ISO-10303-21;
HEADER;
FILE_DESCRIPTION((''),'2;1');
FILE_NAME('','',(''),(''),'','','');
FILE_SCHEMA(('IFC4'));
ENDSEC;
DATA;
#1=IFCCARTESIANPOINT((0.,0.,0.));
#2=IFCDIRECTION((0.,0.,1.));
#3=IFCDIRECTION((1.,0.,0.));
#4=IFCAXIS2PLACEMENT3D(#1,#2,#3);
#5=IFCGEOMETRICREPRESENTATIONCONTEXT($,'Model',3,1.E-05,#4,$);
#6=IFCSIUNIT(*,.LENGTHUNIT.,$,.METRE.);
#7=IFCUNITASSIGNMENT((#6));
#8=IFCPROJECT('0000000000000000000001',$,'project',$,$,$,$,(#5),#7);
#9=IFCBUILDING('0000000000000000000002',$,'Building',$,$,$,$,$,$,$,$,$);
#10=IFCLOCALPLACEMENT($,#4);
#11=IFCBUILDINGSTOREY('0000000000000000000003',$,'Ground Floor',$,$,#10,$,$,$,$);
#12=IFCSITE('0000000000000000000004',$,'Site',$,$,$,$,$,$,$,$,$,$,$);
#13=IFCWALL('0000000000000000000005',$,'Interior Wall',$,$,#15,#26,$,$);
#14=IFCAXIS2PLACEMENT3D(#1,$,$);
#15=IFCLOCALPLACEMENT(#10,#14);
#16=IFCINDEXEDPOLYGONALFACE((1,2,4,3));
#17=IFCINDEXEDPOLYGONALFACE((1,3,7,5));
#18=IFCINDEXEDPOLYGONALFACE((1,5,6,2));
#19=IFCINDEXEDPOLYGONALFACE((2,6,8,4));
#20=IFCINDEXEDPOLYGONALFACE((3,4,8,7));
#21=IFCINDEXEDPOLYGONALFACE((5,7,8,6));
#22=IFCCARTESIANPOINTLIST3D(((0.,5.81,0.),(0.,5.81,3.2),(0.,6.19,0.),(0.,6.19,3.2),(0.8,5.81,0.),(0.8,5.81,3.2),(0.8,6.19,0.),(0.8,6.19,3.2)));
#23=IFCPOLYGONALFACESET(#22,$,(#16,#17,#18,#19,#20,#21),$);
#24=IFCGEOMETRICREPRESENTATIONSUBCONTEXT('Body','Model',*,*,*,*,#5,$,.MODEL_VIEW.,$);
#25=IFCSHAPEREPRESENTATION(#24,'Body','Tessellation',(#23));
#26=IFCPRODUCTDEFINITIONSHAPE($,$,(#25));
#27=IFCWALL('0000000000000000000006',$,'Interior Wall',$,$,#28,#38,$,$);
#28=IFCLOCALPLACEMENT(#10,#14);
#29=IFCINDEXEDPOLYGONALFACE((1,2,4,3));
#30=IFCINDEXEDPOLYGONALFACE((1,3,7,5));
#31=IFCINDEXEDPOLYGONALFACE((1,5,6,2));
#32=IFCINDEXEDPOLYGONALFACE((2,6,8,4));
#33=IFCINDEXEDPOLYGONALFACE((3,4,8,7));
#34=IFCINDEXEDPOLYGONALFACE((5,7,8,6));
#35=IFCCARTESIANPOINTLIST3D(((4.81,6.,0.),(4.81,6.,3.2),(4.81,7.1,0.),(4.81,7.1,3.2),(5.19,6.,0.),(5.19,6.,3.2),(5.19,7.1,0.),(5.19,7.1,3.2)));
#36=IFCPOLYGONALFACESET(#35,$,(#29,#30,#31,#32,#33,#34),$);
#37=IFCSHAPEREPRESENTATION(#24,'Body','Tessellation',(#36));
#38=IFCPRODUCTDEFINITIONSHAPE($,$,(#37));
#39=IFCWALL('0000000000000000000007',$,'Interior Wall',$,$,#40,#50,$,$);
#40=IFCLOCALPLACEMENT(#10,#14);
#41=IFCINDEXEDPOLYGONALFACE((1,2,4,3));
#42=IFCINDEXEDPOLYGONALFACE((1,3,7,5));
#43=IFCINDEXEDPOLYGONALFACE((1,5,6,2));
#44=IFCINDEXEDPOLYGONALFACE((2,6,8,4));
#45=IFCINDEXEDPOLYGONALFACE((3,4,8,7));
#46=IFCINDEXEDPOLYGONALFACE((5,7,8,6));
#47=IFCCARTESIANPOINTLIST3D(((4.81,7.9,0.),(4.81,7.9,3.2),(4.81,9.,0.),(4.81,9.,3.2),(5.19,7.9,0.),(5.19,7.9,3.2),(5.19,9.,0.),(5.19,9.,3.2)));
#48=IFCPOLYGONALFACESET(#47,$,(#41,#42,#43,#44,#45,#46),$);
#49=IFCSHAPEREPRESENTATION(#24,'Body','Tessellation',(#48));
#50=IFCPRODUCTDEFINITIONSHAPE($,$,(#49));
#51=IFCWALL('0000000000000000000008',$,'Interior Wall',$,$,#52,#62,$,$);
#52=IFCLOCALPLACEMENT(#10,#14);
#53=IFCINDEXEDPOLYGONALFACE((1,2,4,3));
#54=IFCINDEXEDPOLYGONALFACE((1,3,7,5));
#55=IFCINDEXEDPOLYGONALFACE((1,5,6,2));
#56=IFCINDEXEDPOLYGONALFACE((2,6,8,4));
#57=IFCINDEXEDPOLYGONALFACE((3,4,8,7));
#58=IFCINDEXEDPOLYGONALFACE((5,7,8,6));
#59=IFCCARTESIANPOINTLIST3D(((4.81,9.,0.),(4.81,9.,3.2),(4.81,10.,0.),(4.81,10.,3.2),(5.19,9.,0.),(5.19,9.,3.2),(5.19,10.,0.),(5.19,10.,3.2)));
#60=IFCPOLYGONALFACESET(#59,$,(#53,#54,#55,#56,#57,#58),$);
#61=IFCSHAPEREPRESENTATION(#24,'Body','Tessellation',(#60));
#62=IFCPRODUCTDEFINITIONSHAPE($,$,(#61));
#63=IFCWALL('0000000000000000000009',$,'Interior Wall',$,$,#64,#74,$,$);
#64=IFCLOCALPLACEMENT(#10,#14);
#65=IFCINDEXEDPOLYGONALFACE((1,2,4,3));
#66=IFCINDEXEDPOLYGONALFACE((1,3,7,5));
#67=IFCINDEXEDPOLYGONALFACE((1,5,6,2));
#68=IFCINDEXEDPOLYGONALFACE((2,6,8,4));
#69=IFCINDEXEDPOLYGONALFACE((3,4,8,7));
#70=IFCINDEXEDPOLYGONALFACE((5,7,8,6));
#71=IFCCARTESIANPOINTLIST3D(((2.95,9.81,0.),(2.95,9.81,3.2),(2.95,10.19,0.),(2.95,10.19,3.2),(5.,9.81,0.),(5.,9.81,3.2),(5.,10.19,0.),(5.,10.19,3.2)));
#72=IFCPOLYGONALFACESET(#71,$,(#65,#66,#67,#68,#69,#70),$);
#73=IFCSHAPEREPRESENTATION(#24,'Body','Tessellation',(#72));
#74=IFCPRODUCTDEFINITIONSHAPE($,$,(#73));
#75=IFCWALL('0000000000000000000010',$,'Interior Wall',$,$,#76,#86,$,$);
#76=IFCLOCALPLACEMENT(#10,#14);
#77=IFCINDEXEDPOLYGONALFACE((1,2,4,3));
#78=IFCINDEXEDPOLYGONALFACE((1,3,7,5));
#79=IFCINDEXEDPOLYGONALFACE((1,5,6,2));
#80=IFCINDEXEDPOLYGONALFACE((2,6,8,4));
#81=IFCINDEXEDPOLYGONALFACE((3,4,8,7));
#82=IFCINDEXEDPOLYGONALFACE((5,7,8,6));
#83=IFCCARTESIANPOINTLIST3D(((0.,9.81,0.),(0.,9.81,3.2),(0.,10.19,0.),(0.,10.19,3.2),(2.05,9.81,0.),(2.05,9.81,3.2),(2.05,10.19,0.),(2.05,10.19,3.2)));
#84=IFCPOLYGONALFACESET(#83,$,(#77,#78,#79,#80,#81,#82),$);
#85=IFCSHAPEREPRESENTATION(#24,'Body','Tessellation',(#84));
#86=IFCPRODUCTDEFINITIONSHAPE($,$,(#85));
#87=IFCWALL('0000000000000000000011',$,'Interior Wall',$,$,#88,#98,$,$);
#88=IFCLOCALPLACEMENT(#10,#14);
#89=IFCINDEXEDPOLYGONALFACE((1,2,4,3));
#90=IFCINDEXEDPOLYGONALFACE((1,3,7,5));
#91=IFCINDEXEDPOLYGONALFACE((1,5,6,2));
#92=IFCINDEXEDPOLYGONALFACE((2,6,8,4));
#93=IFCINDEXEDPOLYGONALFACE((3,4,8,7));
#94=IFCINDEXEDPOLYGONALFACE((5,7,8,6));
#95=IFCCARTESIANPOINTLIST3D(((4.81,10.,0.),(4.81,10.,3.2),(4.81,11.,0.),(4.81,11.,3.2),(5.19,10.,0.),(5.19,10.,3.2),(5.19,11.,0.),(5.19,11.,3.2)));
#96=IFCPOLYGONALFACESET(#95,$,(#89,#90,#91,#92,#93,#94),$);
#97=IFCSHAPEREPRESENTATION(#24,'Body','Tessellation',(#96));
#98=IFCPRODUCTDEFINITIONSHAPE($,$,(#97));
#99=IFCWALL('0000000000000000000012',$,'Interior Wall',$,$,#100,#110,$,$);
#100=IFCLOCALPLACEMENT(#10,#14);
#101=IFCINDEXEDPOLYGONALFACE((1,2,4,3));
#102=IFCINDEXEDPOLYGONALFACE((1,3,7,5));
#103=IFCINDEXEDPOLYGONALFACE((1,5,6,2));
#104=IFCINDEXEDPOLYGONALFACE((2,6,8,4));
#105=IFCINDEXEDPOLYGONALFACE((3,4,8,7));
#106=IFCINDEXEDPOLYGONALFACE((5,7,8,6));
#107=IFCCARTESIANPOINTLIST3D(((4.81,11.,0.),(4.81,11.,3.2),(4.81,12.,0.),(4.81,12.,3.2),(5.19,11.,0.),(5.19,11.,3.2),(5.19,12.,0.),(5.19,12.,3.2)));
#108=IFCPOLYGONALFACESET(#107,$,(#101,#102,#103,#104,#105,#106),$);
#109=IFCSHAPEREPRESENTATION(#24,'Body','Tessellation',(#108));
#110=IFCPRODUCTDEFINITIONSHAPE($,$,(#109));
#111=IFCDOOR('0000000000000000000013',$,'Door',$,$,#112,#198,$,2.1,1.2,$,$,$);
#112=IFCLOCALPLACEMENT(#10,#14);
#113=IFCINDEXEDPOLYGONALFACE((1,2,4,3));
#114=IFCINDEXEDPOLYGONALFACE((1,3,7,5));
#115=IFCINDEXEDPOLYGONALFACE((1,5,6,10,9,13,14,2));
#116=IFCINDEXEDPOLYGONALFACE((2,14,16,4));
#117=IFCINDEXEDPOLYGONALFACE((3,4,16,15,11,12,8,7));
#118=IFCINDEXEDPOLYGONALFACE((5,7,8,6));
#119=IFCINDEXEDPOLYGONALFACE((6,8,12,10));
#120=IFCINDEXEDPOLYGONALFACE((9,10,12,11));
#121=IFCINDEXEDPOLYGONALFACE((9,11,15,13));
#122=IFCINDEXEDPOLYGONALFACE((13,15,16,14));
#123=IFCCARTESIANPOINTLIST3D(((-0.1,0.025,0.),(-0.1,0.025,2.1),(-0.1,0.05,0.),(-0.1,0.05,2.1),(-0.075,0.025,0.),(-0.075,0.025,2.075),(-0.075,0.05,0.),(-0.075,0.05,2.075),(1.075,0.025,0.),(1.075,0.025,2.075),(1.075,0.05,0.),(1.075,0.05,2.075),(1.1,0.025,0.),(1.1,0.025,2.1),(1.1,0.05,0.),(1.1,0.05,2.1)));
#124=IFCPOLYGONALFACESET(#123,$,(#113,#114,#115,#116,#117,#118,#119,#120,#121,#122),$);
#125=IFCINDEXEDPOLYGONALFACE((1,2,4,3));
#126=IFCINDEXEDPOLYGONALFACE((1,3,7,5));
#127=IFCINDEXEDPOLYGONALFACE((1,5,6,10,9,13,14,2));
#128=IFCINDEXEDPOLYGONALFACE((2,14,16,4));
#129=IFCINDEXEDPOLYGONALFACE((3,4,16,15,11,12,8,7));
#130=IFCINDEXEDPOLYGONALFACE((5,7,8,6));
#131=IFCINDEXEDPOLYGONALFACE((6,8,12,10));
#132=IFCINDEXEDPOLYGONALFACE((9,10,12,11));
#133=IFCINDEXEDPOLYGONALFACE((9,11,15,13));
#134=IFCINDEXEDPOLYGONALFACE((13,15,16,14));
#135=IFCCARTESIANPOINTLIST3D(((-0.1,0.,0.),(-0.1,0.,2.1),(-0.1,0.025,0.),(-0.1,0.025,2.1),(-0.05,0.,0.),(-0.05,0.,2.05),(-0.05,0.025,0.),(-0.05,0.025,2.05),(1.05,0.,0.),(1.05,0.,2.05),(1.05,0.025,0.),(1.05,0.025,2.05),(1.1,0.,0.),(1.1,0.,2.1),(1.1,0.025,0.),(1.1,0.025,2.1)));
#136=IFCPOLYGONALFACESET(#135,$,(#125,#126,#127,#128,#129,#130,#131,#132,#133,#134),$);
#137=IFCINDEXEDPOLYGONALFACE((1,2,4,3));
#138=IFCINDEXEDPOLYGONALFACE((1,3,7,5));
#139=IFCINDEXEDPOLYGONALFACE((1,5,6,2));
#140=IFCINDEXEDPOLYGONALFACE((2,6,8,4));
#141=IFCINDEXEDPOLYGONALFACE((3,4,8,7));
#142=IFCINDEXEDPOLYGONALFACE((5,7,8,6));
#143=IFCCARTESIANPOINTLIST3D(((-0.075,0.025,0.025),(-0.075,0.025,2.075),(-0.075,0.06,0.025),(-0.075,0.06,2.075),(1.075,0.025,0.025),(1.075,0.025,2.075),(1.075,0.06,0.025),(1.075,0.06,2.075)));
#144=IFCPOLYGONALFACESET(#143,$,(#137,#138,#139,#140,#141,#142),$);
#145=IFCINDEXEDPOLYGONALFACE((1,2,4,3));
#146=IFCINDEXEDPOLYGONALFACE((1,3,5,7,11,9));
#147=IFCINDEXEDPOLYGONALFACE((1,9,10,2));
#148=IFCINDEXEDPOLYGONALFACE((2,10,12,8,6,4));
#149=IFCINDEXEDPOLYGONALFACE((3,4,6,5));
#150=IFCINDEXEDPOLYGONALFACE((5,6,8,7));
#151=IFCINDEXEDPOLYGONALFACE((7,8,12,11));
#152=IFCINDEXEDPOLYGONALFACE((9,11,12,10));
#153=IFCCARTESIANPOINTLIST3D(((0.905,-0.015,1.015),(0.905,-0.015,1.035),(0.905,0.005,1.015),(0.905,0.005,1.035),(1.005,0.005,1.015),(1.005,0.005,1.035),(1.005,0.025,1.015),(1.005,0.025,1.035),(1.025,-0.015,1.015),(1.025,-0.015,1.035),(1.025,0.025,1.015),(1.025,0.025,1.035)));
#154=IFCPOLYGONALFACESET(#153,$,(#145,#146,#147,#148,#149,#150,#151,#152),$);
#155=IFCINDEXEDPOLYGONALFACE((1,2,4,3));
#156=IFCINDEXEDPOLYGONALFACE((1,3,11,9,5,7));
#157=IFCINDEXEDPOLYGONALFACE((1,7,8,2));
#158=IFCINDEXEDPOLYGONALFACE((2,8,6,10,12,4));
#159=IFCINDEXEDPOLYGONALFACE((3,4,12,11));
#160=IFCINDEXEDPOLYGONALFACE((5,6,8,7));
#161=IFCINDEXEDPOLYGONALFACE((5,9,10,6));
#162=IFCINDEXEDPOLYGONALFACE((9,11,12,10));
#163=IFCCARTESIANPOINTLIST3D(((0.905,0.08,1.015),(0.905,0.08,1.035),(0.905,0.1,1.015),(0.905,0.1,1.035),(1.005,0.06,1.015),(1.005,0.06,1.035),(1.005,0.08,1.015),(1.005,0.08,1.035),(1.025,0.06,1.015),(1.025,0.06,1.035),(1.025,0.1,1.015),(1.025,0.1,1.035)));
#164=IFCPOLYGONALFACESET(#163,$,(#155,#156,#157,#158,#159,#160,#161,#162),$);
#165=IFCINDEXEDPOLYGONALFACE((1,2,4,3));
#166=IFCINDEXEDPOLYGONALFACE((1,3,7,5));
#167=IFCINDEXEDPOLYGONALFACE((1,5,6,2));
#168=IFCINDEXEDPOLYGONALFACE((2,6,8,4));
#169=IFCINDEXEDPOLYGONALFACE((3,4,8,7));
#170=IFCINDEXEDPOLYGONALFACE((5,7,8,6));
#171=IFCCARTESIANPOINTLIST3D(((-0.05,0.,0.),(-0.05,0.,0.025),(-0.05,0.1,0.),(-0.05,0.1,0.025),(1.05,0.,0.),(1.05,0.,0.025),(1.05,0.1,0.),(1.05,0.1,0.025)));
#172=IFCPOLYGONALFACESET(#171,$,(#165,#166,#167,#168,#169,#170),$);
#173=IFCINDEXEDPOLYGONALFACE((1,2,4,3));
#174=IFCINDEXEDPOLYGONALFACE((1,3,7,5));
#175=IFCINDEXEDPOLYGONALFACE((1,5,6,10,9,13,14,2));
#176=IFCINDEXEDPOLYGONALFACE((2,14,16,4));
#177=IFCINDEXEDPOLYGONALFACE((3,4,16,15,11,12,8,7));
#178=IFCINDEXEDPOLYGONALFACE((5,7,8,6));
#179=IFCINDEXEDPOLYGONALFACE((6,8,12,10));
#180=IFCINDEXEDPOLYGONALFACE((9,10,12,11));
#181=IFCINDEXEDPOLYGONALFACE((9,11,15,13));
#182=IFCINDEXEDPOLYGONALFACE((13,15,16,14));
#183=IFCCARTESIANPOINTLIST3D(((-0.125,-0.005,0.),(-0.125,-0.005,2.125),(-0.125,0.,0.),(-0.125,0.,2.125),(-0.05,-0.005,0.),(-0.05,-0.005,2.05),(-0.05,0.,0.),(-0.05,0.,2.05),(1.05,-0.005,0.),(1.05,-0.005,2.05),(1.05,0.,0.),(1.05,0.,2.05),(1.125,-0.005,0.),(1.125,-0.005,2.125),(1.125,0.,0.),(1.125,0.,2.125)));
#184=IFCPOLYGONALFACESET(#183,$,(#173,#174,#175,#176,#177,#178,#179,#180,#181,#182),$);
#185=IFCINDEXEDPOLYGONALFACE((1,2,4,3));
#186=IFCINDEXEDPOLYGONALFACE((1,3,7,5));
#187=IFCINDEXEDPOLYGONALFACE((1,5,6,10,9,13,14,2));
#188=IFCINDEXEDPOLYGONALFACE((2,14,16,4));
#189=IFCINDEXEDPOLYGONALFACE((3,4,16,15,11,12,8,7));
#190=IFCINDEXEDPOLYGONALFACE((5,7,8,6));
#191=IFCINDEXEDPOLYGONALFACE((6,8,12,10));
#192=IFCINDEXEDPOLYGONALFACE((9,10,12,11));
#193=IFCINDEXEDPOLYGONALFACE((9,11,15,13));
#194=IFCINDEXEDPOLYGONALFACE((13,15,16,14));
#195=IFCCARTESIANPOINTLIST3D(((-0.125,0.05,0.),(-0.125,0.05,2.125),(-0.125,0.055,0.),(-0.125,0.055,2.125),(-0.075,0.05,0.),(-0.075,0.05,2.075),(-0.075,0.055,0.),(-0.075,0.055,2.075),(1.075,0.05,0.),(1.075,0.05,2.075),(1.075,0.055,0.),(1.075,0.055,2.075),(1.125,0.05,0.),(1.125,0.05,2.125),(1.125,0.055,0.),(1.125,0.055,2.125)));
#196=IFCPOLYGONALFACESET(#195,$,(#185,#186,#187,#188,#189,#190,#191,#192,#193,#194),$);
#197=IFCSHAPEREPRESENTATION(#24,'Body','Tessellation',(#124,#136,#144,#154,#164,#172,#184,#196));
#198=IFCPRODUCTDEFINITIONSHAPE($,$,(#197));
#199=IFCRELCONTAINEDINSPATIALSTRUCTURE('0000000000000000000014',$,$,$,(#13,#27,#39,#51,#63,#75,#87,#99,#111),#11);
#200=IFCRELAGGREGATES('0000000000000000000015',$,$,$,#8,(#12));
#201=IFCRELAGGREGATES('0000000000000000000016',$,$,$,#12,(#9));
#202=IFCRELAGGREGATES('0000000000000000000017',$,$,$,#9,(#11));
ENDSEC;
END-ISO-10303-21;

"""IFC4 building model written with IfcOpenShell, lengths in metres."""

from ifc_helpers import new_model, si_unit, frame, origin_with_axes, place, context, subcontext, project, spatial, line, indexed_curve, outline, extrude, element, save


model = new_model("IFC4")

# Units and contexts
model_context = context("Model", 3, precision=1e-05, world=origin_with_axes())
body_context = subcontext(model_context, "Body", "Model", "MODEL_VIEW")
ifc_project = project(units=[si_unit("LENGTHUNIT", "METRE")], contexts=[model_context])

# Site, building, storey
site = spatial("IfcSite", under=ifc_project, Name="Site")
building = spatial("IfcBuilding", under=site, Name="Building")
storey_placement = place(None, origin_with_axes())
storey = spatial("IfcBuildingStorey", under=building, at=storey_placement, Name="Ground Floor")

# Walls
for number, where, z_axis, x_axis, name in (
    (1, (0.8, 6.0, 0.0), (0.0, 0.0, 1.0), (-1.0, 0.0, 0.0), "Interior Wall"),
):
    element("IfcWall", number, at=place(storey_placement, frame(where, z_axis=z_axis, x_axis=x_axis)), inside=storey, Name=name, context=body_context, shape_type="SweptSolid", body=[
        extrude(outline(indexed_curve([(0.0, 0.0), (0.0, 0.38), (0.8, 0.38), (0.8, 0.0), (0.0, 0.0)], self_intersect=False)), frame((0.0, -0.19, 0.0), z_axis=(0.0, 0.0, 1.0), x_axis=(1.0, 0.0, 0.0)), (0.0, 0.0, 1.0), 3.2),
    ])
for number, where, z_axis, x_axis, name in (
    (2, (5.0, 6.0, 0.0), (0.0, 0.0, 1.0), (0.0, 1.0, 0.0), "Interior Wall"),
    (3, (5.0, 7.9, 0.0), (0.0, 0.0, 1.0), (0.0, 1.0, 0.0), "Interior Wall"),
):
    element("IfcWall", number, at=place(storey_placement, frame(where, z_axis=z_axis, x_axis=x_axis)), inside=storey, Name=name, context=body_context, shape_type="SweptSolid", body=[
        extrude(outline(indexed_curve([(0.0, 0.0), (0.0, 0.38), (1.1, 0.38), (1.1, 0.0), (0.0, 0.0)], self_intersect=False)), frame((0.0, -0.19, 0.0), z_axis=(0.0, 0.0, 1.0), x_axis=(1.0, 0.0, 0.0)), (0.0, 0.0, 1.0), 3.2),
    ])
wall_1_placement = place(storey_placement, frame((5.0, 9.0, 0.0), z_axis=(0.0, 0.0, 1.0), x_axis=(0.0, 1.0, 0.0)))
element("IfcWall", 4, at=wall_1_placement, inside=storey, Name="Interior Wall", context=body_context, shape_type="SweptSolid", body=[
    extrude(outline(indexed_curve([(0.0, 0.0), (0.0, 0.38), (1.0, 0.38), (1.0, 0.0), (0.0, 0.0)], self_intersect=False)), frame((0.0, -0.19, 0.0), z_axis=(0.0, 0.0, 1.0), x_axis=(1.0, 0.0, 0.0)), (0.0, 0.0, 1.0), 3.2),
])
for number, where, z_axis, x_axis, name in (
    (5, (5.0, 10.0, 0.0), (0.0, 0.0, 1.0), (-1.0, 0.0, 0.0), "Interior Wall"),
    (6, (2.05, 10.0, 0.0), (0.0, 0.0, 1.0), (-1.0, 0.0, 0.0), "Interior Wall"),
):
    element("IfcWall", number, at=place(storey_placement, frame(where, z_axis=z_axis, x_axis=x_axis)), inside=storey, Name=name, context=body_context, shape_type="SweptSolid", body=[
        extrude(outline(indexed_curve([(0.0, 0.0), (0.0, 0.38), (2.05, 0.38), (2.05, 0.0), (0.0, 0.0)], self_intersect=False)), frame((0.0, -0.19, 0.0), z_axis=(0.0, 0.0, 1.0), x_axis=(1.0, 0.0, 0.0)), (0.0, 0.0, 1.0), 3.2),
    ])
for number, where, z_axis, x_axis, name in (
    (7, (5.0, 11.0, 0.0), (0.0, 0.0, 1.0), (0.0, -1.0, 0.0), "Interior Wall"),
    (8, (5.0, 11.0, 0.0), (0.0, 0.0, 1.0), (0.0, 1.0, 0.0), "Interior Wall"),
):
    element("IfcWall", number, at=place(storey_placement, frame(where, z_axis=z_axis, x_axis=x_axis)), inside=storey, Name=name, context=body_context, shape_type="SweptSolid", body=[
        extrude(outline(indexed_curve([(0.0, 0.0), (0.0, 0.38), (1.0, 0.38), (1.0, 0.0), (0.0, 0.0)], self_intersect=False)), frame((0.0, -0.19, 0.0), z_axis=(0.0, 0.0, 1.0), x_axis=(1.0, 0.0, 0.0)), (0.0, 0.0, 1.0), 3.2),
    ])

# Door
door_1_placement = place(storey_placement, frame((-0.1, 0.0, 0.0), z_axis=(0.0, 0.0, 1.0), x_axis=(1.0, 0.0, 0.0)))
element("IfcDoor", 9, at=door_1_placement, inside=storey, Name="Door", OverallHeight=2.1, OverallWidth=1.2, context=body_context, shape_type="SweptSolid", body=[
    extrude(outline(indexed_curve([(0.0, 0.0), (0.0, 2.1), (1.2, 2.1), (1.2, 0.0), (1.175, 0.0), (1.175, 2.075), (0.025, 2.075), (0.025, 0.0)], segments=[line(1, 2, 3, 4, 5, 6, 7, 8, 1)])), frame((0.0, 0.025, 0.0), z_axis=(0.0, -1.0, 0.0), x_axis=(1.0, 0.0, 0.0)), (0.0, 0.0, -1.0), 0.025),
    extrude(outline(indexed_curve([(0.0, 0.0), (0.0, 2.1), (1.2, 2.1), (1.2, 0.0), (1.15, 0.0), (1.15, 2.05), (0.05, 2.05), (0.05, 0.0)], segments=[line(1, 2, 3, 4, 5, 6, 7, 8, 1)])), frame((0.0, 0.0, 0.0), z_axis=(0.0, -1.0, 0.0), x_axis=(1.0, 0.0, 0.0)), (0.0, 0.0, -1.0), 0.025),
    extrude(outline(indexed_curve([(0.0, 0.0), (1.15, 0.0), (1.15, 0.035), (0.0, 0.035)], segments=[line(1, 2, 3, 4, 1)])), frame((0.025, 0.025, 0.025), z_axis=(0.0, 0.0, 1.0), x_axis=(1.0, 0.0, 0.0)), (0.0, 0.0, 1.0), 2.05),
    extrude(outline(indexed_curve([(0.0, 0.0), (0.0, -0.04), (-0.12, -0.04), (-0.12, -0.02), (-0.02, -0.02), (-0.02, 0.0)], segments=[line(1, 2, 3, 4, 5, 6, 1)])), frame((1.125, 0.025, 1.015), z_axis=(0.0, 0.0, 1.0), x_axis=(1.0, 0.0, 0.0)), (0.0, 0.0, 1.0), 0.02),
    extrude(outline(indexed_curve([(0.0, 0.0), (0.0, 0.04), (-0.12, 0.04), (-0.12, 0.02), (-0.02, 0.02), (-0.02, 0.0)], segments=[line(1, 2, 3, 4, 5, 6, 1)])), frame((1.125, 0.06, 1.015), z_axis=(0.0, 0.0, 1.0), x_axis=(1.0, 0.0, 0.0)), (0.0, 0.0, 1.0), 0.02),
    extrude(outline(indexed_curve([(0.0, 0.0), (1.1, 0.0), (1.1, 0.1), (0.0, 0.1)], segments=[line(1, 2, 3, 4, 1)])), frame((0.05, 0.0, 0.0), z_axis=(0.0, 0.0, 1.0), x_axis=(1.0, 0.0, 0.0)), (0.0, 0.0, 1.0), 0.025),
    extrude(outline(indexed_curve([(0.0, 0.0), (0.0, 2.125), (1.25, 2.125), (1.25, 0.0), (1.175, 0.0), (1.175, 2.05), (0.075, 2.05), (0.075, 0.0)], segments=[line(1, 2, 3, 4, 5, 6, 7, 8, 1)])), frame((-0.025, -0.005, 0.0), z_axis=(0.0, -1.0, 0.0), x_axis=(1.0, 0.0, 0.0)), (0.0, 0.0, -1.0), 0.005),
    extrude(outline(indexed_curve([(0.0, 0.0), (0.0, 2.125), (1.25, 2.125), (1.25, 0.0), (1.2, 0.0), (1.2, 2.075), (0.05, 2.075), (0.05, 0.0)], segments=[line(1, 2, 3, 4, 5, 6, 7, 8, 1)])), frame((-0.025, 0.05, 0.0), z_axis=(0.0, -1.0, 0.0), x_axis=(1.0, 0.0, 0.0)), (0.0, 0.0, -1.0), 0.005),
])

save(model, "model.ifc")
